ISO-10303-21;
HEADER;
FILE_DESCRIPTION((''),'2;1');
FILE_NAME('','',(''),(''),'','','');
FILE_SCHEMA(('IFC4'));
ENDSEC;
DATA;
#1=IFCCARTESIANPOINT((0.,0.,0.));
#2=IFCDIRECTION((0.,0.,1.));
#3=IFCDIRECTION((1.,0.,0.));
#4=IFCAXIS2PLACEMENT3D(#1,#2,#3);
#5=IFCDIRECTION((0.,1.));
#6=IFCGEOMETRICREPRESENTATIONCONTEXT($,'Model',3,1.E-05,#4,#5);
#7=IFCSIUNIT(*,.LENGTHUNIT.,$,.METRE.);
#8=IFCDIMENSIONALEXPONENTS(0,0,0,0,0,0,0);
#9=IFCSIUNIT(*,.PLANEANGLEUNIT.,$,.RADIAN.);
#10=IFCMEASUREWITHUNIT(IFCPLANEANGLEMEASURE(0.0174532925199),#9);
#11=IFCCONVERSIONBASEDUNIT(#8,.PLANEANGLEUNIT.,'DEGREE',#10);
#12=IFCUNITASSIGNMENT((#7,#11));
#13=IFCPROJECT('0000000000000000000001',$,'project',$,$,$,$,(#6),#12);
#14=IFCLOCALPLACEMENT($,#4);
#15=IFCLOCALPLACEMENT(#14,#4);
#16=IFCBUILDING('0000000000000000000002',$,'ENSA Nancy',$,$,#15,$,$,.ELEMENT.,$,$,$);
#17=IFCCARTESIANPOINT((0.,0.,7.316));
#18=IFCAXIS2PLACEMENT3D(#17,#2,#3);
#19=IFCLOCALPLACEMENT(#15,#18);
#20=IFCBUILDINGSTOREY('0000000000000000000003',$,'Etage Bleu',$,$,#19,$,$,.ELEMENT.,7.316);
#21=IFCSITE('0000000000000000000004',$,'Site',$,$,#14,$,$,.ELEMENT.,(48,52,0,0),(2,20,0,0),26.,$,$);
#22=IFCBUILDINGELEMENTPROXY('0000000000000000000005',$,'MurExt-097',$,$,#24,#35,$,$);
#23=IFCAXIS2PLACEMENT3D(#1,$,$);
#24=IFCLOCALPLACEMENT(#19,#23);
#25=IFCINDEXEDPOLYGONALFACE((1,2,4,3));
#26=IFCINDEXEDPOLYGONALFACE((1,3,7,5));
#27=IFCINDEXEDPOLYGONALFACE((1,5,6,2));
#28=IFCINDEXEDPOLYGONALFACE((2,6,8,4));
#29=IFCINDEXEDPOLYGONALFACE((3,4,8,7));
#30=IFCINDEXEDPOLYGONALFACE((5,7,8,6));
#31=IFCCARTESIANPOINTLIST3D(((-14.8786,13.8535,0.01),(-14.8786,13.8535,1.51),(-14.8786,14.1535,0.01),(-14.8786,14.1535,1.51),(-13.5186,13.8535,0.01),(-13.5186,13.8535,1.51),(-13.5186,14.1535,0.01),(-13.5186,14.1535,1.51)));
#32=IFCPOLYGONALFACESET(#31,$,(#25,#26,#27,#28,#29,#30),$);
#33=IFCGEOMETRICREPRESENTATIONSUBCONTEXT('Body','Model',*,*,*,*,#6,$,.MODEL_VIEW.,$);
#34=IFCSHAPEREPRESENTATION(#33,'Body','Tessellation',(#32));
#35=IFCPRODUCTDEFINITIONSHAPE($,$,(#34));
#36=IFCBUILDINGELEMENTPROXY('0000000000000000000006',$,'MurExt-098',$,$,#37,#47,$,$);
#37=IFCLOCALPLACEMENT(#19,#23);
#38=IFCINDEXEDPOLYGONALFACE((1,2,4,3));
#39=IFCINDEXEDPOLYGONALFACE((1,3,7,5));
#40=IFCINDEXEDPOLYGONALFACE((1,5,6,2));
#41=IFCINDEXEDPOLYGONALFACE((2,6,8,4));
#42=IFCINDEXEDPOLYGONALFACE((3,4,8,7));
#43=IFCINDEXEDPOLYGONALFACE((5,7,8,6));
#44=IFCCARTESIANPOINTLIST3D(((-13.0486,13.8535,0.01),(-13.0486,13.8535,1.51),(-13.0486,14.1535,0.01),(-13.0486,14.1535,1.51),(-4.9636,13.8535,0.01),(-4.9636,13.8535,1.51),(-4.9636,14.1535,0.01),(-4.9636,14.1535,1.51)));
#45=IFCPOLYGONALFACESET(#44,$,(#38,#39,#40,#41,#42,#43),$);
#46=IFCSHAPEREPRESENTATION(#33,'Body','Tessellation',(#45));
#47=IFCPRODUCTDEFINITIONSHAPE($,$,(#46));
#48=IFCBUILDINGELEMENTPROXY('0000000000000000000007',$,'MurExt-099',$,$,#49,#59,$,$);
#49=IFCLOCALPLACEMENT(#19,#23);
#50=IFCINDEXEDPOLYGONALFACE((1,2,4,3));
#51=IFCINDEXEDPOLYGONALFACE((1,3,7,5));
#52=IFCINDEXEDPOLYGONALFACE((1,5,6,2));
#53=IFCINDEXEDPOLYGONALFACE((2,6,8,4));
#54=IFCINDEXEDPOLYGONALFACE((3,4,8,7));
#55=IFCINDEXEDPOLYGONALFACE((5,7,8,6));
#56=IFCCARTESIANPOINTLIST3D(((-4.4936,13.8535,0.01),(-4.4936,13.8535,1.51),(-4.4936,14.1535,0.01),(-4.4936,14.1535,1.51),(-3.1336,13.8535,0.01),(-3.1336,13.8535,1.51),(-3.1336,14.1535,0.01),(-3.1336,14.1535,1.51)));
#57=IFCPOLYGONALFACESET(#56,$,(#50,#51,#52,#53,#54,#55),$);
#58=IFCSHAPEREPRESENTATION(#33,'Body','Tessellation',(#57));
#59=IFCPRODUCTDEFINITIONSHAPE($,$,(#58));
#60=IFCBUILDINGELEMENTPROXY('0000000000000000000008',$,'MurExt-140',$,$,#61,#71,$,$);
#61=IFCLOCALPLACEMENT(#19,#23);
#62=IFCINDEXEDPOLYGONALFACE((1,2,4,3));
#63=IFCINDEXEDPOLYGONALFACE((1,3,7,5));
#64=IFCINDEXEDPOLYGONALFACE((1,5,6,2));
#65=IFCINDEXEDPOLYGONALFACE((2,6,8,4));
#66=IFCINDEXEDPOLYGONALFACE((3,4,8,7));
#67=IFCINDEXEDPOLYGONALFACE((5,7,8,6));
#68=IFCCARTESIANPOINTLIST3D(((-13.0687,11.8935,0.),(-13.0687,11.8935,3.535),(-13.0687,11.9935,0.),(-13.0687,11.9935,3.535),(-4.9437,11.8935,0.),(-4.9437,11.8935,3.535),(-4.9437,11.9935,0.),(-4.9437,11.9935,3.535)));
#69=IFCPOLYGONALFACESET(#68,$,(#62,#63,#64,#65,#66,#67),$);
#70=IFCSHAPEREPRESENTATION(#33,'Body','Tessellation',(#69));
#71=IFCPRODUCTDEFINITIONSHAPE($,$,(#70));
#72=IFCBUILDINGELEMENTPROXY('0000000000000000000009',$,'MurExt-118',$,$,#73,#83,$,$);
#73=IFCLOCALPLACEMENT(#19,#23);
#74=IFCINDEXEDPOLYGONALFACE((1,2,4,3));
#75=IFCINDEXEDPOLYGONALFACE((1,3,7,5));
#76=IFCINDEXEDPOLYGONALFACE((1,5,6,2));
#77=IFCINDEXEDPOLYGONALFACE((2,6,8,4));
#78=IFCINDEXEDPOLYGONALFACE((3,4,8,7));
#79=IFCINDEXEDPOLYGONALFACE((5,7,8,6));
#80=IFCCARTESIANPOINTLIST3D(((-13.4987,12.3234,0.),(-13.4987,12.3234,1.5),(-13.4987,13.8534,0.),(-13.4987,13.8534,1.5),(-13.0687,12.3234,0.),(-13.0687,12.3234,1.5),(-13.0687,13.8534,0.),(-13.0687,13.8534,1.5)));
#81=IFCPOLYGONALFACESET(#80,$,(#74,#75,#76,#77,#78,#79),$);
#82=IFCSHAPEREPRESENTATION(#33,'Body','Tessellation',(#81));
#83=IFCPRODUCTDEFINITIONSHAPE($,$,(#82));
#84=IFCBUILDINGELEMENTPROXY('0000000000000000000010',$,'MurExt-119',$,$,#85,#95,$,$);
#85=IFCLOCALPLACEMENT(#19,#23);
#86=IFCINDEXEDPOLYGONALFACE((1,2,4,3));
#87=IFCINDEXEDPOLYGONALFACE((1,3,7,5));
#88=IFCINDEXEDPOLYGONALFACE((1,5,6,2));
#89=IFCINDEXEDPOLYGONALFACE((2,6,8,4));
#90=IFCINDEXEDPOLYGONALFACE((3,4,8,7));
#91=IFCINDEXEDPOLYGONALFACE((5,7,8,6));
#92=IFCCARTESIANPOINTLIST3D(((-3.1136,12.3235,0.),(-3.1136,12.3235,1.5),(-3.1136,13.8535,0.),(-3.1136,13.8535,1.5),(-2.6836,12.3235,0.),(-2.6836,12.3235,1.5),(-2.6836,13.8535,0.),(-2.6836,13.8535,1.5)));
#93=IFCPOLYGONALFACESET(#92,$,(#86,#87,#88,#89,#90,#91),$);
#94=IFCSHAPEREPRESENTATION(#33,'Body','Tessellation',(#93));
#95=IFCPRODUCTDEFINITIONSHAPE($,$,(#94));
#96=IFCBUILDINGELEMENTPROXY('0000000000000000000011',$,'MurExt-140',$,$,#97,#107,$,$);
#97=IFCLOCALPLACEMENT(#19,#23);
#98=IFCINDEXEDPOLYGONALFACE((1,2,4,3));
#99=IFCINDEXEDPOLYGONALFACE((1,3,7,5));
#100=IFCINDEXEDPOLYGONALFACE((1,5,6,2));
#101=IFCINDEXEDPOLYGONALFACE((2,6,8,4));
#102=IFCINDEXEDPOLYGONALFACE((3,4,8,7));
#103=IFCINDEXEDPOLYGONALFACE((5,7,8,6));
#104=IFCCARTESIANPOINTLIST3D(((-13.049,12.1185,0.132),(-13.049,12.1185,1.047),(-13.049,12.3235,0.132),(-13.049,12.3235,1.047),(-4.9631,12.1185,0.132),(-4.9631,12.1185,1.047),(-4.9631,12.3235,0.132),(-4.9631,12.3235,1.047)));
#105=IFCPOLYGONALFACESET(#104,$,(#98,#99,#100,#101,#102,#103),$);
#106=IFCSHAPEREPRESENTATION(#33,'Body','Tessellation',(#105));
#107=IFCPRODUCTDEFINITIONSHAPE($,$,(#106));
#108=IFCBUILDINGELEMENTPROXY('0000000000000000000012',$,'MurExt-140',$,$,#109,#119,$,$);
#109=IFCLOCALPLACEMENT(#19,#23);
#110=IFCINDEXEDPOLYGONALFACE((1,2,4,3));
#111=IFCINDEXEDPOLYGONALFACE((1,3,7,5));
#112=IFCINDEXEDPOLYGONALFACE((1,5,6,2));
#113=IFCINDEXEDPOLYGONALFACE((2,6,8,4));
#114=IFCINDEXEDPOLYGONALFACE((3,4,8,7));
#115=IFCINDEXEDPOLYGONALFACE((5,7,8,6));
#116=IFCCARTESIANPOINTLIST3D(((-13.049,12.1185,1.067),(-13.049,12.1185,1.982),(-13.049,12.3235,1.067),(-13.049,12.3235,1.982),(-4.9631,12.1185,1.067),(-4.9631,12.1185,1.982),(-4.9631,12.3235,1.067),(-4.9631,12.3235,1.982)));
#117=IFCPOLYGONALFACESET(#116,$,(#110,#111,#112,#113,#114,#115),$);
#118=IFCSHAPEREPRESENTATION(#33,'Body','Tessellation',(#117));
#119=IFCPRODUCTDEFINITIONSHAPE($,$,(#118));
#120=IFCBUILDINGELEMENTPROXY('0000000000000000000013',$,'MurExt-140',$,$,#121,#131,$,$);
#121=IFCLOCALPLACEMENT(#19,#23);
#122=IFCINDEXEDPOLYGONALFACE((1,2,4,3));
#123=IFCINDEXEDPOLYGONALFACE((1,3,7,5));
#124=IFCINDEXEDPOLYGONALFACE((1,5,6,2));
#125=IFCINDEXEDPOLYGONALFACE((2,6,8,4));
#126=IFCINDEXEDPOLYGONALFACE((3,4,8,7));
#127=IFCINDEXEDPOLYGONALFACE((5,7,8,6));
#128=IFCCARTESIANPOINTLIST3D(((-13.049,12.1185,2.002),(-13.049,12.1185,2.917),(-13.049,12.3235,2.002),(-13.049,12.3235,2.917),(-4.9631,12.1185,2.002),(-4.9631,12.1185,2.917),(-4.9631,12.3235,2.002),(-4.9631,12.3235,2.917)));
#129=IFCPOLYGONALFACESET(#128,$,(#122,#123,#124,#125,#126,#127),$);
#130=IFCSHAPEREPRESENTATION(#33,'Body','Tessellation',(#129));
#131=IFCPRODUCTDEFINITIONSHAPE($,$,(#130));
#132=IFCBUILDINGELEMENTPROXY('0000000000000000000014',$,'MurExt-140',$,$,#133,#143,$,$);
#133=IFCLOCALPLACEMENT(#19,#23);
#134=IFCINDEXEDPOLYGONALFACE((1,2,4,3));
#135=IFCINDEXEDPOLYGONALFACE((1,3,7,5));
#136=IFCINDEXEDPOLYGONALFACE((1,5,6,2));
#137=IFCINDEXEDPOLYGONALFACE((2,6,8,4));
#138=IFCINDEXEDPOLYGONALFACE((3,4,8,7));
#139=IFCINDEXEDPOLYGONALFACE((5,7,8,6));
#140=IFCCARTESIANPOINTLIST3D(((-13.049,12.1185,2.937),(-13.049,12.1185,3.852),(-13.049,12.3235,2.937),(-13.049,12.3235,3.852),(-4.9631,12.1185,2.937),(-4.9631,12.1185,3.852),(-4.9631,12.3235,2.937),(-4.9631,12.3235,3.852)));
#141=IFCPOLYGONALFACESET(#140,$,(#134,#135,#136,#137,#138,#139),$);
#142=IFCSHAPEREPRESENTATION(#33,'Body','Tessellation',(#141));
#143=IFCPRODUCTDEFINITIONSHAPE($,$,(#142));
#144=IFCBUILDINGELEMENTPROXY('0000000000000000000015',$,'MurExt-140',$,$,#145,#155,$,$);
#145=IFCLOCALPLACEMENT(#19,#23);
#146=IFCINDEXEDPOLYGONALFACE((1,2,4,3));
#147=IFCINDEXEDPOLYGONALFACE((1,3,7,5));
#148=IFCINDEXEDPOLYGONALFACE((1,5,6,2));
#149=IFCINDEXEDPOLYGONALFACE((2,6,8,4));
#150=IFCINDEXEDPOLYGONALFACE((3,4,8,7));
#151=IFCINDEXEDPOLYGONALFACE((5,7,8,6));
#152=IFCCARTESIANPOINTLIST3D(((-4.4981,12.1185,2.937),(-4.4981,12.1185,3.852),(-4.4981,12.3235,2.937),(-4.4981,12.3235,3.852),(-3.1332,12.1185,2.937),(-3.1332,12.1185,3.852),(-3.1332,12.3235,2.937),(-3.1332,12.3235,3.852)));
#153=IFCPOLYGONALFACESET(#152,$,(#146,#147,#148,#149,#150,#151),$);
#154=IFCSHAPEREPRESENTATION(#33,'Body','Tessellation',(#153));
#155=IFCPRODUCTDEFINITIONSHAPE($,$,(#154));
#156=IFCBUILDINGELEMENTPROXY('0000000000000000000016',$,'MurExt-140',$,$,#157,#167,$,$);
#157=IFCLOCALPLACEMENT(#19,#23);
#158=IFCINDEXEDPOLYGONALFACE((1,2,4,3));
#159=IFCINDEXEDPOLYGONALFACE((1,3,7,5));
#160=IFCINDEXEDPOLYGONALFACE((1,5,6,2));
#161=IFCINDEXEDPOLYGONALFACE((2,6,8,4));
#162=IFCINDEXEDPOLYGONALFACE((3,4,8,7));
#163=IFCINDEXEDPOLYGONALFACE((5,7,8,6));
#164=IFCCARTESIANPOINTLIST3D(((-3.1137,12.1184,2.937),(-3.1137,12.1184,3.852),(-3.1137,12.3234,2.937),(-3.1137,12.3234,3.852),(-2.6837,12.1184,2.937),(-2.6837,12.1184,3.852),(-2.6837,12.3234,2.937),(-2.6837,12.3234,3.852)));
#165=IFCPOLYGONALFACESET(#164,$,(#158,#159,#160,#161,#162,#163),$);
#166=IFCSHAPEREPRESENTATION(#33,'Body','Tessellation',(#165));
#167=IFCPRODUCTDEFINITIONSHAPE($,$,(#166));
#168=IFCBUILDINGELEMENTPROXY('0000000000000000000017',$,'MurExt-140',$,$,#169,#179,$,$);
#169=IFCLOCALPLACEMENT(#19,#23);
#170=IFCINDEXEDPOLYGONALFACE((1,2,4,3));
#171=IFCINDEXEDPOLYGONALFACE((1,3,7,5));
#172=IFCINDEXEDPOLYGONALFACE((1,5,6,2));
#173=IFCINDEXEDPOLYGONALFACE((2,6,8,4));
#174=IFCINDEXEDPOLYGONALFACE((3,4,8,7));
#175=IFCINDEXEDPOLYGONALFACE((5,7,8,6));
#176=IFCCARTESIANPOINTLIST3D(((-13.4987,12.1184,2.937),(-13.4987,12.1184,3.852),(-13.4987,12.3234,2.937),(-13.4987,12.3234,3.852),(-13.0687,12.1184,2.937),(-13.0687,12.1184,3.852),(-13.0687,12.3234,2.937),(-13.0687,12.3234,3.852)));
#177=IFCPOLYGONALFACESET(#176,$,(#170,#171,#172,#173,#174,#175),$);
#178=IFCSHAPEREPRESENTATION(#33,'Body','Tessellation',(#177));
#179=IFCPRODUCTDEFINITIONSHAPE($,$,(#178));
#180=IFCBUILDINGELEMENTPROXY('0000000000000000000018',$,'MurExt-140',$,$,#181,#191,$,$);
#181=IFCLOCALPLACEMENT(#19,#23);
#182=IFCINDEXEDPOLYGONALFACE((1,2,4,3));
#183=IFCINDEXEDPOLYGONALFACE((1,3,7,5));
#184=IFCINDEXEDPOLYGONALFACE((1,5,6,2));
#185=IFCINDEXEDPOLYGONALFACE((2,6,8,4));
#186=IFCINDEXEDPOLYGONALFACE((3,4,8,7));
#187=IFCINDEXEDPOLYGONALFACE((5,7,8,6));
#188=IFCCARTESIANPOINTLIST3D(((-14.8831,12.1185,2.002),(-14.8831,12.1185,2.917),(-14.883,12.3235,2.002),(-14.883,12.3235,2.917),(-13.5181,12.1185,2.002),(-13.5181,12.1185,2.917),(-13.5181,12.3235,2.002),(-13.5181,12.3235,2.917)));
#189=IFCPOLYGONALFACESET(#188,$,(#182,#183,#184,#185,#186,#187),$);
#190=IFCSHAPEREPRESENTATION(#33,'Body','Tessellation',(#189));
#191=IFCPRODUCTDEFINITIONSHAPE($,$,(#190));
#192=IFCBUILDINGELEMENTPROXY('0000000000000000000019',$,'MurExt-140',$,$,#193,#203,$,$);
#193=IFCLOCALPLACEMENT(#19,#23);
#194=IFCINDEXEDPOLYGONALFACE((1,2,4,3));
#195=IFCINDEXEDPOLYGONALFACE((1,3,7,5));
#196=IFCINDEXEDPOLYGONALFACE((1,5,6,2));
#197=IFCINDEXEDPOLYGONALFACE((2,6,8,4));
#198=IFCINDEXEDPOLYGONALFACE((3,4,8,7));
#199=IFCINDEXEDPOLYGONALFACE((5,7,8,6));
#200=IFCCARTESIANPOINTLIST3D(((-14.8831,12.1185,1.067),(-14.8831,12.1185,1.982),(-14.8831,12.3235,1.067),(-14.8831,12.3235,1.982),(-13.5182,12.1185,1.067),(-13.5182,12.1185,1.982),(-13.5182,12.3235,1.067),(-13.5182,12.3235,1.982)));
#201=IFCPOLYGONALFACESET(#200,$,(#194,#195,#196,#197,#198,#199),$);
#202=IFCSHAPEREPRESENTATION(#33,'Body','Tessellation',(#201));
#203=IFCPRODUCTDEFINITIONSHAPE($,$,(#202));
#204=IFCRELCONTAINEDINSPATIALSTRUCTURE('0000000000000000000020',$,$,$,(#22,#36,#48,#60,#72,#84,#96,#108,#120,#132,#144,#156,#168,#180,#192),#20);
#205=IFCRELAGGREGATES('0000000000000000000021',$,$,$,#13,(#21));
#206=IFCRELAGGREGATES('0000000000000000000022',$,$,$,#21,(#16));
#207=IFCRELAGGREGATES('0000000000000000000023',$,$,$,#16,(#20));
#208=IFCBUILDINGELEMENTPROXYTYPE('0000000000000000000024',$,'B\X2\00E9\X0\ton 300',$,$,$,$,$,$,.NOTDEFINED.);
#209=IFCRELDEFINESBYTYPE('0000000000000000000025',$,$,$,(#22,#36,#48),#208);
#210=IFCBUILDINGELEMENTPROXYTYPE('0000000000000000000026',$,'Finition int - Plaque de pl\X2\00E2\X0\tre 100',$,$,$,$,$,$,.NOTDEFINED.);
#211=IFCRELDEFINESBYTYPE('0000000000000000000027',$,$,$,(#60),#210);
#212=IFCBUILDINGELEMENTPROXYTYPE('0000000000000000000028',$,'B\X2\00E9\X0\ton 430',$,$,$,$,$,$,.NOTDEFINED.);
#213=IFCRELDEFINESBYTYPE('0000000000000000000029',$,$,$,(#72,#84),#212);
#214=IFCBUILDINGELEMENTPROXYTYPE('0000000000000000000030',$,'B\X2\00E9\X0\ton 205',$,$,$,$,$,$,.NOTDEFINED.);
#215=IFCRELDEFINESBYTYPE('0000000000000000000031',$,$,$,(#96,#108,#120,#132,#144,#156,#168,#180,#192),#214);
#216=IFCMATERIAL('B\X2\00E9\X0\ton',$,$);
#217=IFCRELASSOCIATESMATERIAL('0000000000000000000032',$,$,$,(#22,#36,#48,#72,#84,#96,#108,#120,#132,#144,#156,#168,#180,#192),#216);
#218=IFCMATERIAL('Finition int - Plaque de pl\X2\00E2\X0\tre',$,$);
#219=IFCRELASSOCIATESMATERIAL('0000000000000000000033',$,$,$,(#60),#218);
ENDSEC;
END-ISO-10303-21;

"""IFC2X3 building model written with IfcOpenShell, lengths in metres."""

from ifc_helpers import new_model, entity, si_unit, converted_unit, direction, frame, origin_with_axes, place, context, subcontext, project, spatial, polyline, outline, extrude, material, type_object, element, save


model = new_model("IFC2X3")

# Units and contexts
model_context = context("Model", 3, precision=1e-05, world=origin_with_axes(), true_north=direction((0.0, 1.0)))
body_context = subcontext(model_context, "Body", "Model", "MODEL_VIEW")
ifc_project = project(units=[si_unit("LENGTHUNIT", "METRE"), converted_unit("PLANEANGLEUNIT", "DEGREE", entity("IfcPlaneAngleMeasure", 0.0174532925199), si_unit("PLANEANGLEUNIT", "RADIAN"), dimensions=[0, 0, 0, 0, 0, 0, 0])], contexts=[model_context])

# Site, building, storey
site_placement = place(None, origin_with_axes())
site = spatial("IfcSite", under=ifc_project, at=site_placement, Name="Site", CompositionType="ELEMENT", RefLatitude=(48, 52, 0, 0), RefLongitude=(2, 20, 0, 0), RefElevation=26.0)
building_placement = place(site_placement, origin_with_axes())
building = spatial("IfcBuilding", under=site, at=building_placement, Name="ENSA Nancy", CompositionType="ELEMENT")
storey_placement = place(building_placement, frame((0.0, 0.0, 7.316), z_axis=(0.0, 0.0, 1.0), x_axis=(1.0, 0.0, 0.0)))
storey = spatial("IfcBuildingStorey", under=building, at=storey_placement, Name="Etage Bleu", CompositionType="ELEMENT", Elevation=7.316)

# Building element proxies
ifc_material_1 = material(Name="Béton")
building_element_proxy_type_1 = type_object("IfcBuildingElementProxyType", Name="Béton 300", PredefinedType="NOTDEFINED")
proxy_1_placement = place(storey_placement, frame((-14.8786, 13.8535, 0.01), z_axis=(0.0, 0.0, 1.0), x_axis=(1.0, 0.0, 0.0)))
element("IfcBuildingElementProxy", 1, at=proxy_1_placement, inside=storey, type_object=building_element_proxy_type_1, material=ifc_material_1, Name="MurExt-097", context=body_context, shape_type="SweptSolid", body=[
    extrude(outline(polyline([(0.0, 0.0), (1.36, 0.0), (1.36, 0.3), (0.0, 0.3), (0.0, 0.0)])), origin_with_axes(), (0.0, 0.0, 1.0), 1.5),
])
proxy_2_placement = place(storey_placement, frame((-13.0486, 13.8535, 0.01), z_axis=(0.0, 0.0, 1.0), x_axis=(1.0, 0.0, 0.0)))
element("IfcBuildingElementProxy", 2, at=proxy_2_placement, inside=storey, type_object=building_element_proxy_type_1, material=ifc_material_1, Name="MurExt-098", context=body_context, shape_type="SweptSolid", body=[
    extrude(outline(polyline([(0.0, 0.0), (8.085, 0.0), (8.085, 0.3), (0.0, 0.3), (0.0, 0.0)])), origin_with_axes(), (0.0, 0.0, 1.0), 1.5),
])
proxy_3_placement = place(storey_placement, frame((-4.4936, 13.8535, 0.01), z_axis=(0.0, 0.0, 1.0), x_axis=(1.0, 0.0, 0.0)))
element("IfcBuildingElementProxy", 3, at=proxy_3_placement, inside=storey, type_object=building_element_proxy_type_1, material=ifc_material_1, Name="MurExt-099", context=body_context, shape_type="SweptSolid", body=[
    extrude(outline(polyline([(0.0, 0.0), (1.36, 0.0), (1.36, 0.3), (0.0, 0.3), (0.0, 0.0)])), origin_with_axes(), (0.0, 0.0, 1.0), 1.5),
])
ifc_material_2 = material(Name="Finition int - Plaque de plâtre")
building_element_proxy_type_2 = type_object("IfcBuildingElementProxyType", Name="Finition int - Plaque de plâtre 100", PredefinedType="NOTDEFINED")
proxy_4_placement = place(storey_placement, frame((-13.0687, 11.8935, 0.0), z_axis=(0.0, 0.0, 1.0), x_axis=(1.0, 0.0, 0.0)))
element("IfcBuildingElementProxy", 4, at=proxy_4_placement, inside=storey, type_object=building_element_proxy_type_2, material=ifc_material_2, Name="MurExt-140", context=body_context, shape_type="SweptSolid", body=[
    extrude(outline(polyline([(0.0, 0.0), (8.125, 0.0), (8.125, 0.1), (0.0, 0.1), (0.0, 0.0)])), origin_with_axes(), (0.0, 0.0, 1.0), 3.535),
])
building_element_proxy_type_3 = type_object("IfcBuildingElementProxyType", Name="Béton 430", PredefinedType="NOTDEFINED")
proxy_5_placement = place(storey_placement, frame((-13.4987, 13.8534, 0.0), z_axis=(0.0, 0.0, 1.0), x_axis=(0.0, -1.0, 0.0)))
element("IfcBuildingElementProxy", 5, at=proxy_5_placement, inside=storey, type_object=building_element_proxy_type_3, material=ifc_material_1, Name="MurExt-118", context=body_context, shape_type="SweptSolid", body=[
    extrude(outline(polyline([(0.0, 0.0), (1.53, 0.0), (1.53, 0.43), (0.0, 0.43), (0.0, 0.0)])), origin_with_axes(), (0.0, 0.0, 1.0), 1.5),
])
proxy_6_placement = place(storey_placement, frame((-3.1136, 13.8535, 0.0), z_axis=(0.0, 0.0, 1.0), x_axis=(0.0, -1.0, 0.0)))
element("IfcBuildingElementProxy", 6, at=proxy_6_placement, inside=storey, type_object=building_element_proxy_type_3, material=ifc_material_1, Name="MurExt-119", context=body_context, shape_type="SweptSolid", body=[
    extrude(outline(polyline([(0.0, 0.0), (1.53, 0.0), (1.53, 0.43), (0.0, 0.43), (0.0, 0.0)])), origin_with_axes(), (0.0, 0.0, 1.0), 1.5),
])
building_element_proxy_type_4 = type_object("IfcBuildingElementProxyType", Name="Béton 205", PredefinedType="NOTDEFINED")
for number, where, z_axis, x_axis, name in (
    (7, (-13.049, 12.3235, 0.132), (0.0, 0.0, 1.0), (1.0, 0.0, 0.0), "MurExt-140"),
    (8, (-13.049, 12.3235, 1.067), (0.0, 0.0, 1.0), (1.0, 0.0, 0.0), "MurExt-140"),
    (9, (-13.049, 12.3235, 2.002), (0.0, 0.0, 1.0), (1.0, 0.0, 0.0), "MurExt-140"),
    (10, (-13.049, 12.3235, 2.937), (0.0, 0.0, 1.0), (1.0, 0.0, 0.0), "MurExt-140"),
):
    element("IfcBuildingElementProxy", number, at=place(storey_placement, frame(where, z_axis=z_axis, x_axis=x_axis)), inside=storey, type_object=building_element_proxy_type_4, material=ifc_material_1, Name=name, context=body_context, shape_type="SweptSolid", body=[
        extrude(outline(polyline([(0.0, -0.205), (8.0859, -0.205), (8.0859, 0.0), (0.0, 0.0), (0.0, -0.205)])), origin_with_axes(), (0.0, 0.0, 1.0), 0.915),
    ])
proxy_7_placement = place(storey_placement, frame((-4.4981, 12.3235, 2.937), z_axis=(0.0, 0.0, 1.0), x_axis=(1.0, -0.000005, 0.0)))
element("IfcBuildingElementProxy", 11, at=proxy_7_placement, inside=storey, type_object=building_element_proxy_type_4, material=ifc_material_1, Name="MurExt-140", context=body_context, shape_type="SweptSolid", body=[
    extrude(outline(polyline([(0.0, -0.205), (1.3649, -0.205), (1.3649, 0.0), (0.0, 0.0), (0.0, -0.205)])), origin_with_axes(), (0.0, 0.0, 1.0), 0.915),
])
for number, where, z_axis, x_axis, name in (
    (12, (-3.1137, 12.3234, 2.937), (0.0, 0.0, 1.0), (1.0, 0.0, 0.0), "MurExt-140"),
    (13, (-13.4987, 12.3234, 2.937), (0.0, 0.0, 1.0), (1.0, 0.0, 0.0), "MurExt-140"),
):
    element("IfcBuildingElementProxy", number, at=place(storey_placement, frame(where, z_axis=z_axis, x_axis=x_axis)), inside=storey, type_object=building_element_proxy_type_4, material=ifc_material_1, Name=name, context=body_context, shape_type="SweptSolid", body=[
        extrude(outline(polyline([(0.0, -0.205), (0.43, -0.205), (0.43, 0.0), (0.0, 0.0), (0.0, -0.205)])), origin_with_axes(), (0.0, 0.0, 1.0), 0.915),
    ])
for number, where, z_axis, x_axis, name in (
    (14, (-14.883, 12.3235, 2.002), (0.0, 0.0, 1.0), (1.0, -0.000005, 0.0), "MurExt-140"),
    (15, (-14.8831, 12.3235, 1.067), (0.0, 0.0, 1.0), (1.0, -0.000005, 0.0), "MurExt-140"),
):
    element("IfcBuildingElementProxy", number, at=place(storey_placement, frame(where, z_axis=z_axis, x_axis=x_axis)), inside=storey, type_object=building_element_proxy_type_4, material=ifc_material_1, Name=name, context=body_context, shape_type="SweptSolid", body=[
        extrude(outline(polyline([(0.0, -0.205), (1.3649, -0.205), (1.3649, 0.0), (0.0, 0.0), (0.0, -0.205)])), origin_with_axes(), (0.0, 0.0, 1.0), 0.915),
    ])

save(model, "model.ifc")
